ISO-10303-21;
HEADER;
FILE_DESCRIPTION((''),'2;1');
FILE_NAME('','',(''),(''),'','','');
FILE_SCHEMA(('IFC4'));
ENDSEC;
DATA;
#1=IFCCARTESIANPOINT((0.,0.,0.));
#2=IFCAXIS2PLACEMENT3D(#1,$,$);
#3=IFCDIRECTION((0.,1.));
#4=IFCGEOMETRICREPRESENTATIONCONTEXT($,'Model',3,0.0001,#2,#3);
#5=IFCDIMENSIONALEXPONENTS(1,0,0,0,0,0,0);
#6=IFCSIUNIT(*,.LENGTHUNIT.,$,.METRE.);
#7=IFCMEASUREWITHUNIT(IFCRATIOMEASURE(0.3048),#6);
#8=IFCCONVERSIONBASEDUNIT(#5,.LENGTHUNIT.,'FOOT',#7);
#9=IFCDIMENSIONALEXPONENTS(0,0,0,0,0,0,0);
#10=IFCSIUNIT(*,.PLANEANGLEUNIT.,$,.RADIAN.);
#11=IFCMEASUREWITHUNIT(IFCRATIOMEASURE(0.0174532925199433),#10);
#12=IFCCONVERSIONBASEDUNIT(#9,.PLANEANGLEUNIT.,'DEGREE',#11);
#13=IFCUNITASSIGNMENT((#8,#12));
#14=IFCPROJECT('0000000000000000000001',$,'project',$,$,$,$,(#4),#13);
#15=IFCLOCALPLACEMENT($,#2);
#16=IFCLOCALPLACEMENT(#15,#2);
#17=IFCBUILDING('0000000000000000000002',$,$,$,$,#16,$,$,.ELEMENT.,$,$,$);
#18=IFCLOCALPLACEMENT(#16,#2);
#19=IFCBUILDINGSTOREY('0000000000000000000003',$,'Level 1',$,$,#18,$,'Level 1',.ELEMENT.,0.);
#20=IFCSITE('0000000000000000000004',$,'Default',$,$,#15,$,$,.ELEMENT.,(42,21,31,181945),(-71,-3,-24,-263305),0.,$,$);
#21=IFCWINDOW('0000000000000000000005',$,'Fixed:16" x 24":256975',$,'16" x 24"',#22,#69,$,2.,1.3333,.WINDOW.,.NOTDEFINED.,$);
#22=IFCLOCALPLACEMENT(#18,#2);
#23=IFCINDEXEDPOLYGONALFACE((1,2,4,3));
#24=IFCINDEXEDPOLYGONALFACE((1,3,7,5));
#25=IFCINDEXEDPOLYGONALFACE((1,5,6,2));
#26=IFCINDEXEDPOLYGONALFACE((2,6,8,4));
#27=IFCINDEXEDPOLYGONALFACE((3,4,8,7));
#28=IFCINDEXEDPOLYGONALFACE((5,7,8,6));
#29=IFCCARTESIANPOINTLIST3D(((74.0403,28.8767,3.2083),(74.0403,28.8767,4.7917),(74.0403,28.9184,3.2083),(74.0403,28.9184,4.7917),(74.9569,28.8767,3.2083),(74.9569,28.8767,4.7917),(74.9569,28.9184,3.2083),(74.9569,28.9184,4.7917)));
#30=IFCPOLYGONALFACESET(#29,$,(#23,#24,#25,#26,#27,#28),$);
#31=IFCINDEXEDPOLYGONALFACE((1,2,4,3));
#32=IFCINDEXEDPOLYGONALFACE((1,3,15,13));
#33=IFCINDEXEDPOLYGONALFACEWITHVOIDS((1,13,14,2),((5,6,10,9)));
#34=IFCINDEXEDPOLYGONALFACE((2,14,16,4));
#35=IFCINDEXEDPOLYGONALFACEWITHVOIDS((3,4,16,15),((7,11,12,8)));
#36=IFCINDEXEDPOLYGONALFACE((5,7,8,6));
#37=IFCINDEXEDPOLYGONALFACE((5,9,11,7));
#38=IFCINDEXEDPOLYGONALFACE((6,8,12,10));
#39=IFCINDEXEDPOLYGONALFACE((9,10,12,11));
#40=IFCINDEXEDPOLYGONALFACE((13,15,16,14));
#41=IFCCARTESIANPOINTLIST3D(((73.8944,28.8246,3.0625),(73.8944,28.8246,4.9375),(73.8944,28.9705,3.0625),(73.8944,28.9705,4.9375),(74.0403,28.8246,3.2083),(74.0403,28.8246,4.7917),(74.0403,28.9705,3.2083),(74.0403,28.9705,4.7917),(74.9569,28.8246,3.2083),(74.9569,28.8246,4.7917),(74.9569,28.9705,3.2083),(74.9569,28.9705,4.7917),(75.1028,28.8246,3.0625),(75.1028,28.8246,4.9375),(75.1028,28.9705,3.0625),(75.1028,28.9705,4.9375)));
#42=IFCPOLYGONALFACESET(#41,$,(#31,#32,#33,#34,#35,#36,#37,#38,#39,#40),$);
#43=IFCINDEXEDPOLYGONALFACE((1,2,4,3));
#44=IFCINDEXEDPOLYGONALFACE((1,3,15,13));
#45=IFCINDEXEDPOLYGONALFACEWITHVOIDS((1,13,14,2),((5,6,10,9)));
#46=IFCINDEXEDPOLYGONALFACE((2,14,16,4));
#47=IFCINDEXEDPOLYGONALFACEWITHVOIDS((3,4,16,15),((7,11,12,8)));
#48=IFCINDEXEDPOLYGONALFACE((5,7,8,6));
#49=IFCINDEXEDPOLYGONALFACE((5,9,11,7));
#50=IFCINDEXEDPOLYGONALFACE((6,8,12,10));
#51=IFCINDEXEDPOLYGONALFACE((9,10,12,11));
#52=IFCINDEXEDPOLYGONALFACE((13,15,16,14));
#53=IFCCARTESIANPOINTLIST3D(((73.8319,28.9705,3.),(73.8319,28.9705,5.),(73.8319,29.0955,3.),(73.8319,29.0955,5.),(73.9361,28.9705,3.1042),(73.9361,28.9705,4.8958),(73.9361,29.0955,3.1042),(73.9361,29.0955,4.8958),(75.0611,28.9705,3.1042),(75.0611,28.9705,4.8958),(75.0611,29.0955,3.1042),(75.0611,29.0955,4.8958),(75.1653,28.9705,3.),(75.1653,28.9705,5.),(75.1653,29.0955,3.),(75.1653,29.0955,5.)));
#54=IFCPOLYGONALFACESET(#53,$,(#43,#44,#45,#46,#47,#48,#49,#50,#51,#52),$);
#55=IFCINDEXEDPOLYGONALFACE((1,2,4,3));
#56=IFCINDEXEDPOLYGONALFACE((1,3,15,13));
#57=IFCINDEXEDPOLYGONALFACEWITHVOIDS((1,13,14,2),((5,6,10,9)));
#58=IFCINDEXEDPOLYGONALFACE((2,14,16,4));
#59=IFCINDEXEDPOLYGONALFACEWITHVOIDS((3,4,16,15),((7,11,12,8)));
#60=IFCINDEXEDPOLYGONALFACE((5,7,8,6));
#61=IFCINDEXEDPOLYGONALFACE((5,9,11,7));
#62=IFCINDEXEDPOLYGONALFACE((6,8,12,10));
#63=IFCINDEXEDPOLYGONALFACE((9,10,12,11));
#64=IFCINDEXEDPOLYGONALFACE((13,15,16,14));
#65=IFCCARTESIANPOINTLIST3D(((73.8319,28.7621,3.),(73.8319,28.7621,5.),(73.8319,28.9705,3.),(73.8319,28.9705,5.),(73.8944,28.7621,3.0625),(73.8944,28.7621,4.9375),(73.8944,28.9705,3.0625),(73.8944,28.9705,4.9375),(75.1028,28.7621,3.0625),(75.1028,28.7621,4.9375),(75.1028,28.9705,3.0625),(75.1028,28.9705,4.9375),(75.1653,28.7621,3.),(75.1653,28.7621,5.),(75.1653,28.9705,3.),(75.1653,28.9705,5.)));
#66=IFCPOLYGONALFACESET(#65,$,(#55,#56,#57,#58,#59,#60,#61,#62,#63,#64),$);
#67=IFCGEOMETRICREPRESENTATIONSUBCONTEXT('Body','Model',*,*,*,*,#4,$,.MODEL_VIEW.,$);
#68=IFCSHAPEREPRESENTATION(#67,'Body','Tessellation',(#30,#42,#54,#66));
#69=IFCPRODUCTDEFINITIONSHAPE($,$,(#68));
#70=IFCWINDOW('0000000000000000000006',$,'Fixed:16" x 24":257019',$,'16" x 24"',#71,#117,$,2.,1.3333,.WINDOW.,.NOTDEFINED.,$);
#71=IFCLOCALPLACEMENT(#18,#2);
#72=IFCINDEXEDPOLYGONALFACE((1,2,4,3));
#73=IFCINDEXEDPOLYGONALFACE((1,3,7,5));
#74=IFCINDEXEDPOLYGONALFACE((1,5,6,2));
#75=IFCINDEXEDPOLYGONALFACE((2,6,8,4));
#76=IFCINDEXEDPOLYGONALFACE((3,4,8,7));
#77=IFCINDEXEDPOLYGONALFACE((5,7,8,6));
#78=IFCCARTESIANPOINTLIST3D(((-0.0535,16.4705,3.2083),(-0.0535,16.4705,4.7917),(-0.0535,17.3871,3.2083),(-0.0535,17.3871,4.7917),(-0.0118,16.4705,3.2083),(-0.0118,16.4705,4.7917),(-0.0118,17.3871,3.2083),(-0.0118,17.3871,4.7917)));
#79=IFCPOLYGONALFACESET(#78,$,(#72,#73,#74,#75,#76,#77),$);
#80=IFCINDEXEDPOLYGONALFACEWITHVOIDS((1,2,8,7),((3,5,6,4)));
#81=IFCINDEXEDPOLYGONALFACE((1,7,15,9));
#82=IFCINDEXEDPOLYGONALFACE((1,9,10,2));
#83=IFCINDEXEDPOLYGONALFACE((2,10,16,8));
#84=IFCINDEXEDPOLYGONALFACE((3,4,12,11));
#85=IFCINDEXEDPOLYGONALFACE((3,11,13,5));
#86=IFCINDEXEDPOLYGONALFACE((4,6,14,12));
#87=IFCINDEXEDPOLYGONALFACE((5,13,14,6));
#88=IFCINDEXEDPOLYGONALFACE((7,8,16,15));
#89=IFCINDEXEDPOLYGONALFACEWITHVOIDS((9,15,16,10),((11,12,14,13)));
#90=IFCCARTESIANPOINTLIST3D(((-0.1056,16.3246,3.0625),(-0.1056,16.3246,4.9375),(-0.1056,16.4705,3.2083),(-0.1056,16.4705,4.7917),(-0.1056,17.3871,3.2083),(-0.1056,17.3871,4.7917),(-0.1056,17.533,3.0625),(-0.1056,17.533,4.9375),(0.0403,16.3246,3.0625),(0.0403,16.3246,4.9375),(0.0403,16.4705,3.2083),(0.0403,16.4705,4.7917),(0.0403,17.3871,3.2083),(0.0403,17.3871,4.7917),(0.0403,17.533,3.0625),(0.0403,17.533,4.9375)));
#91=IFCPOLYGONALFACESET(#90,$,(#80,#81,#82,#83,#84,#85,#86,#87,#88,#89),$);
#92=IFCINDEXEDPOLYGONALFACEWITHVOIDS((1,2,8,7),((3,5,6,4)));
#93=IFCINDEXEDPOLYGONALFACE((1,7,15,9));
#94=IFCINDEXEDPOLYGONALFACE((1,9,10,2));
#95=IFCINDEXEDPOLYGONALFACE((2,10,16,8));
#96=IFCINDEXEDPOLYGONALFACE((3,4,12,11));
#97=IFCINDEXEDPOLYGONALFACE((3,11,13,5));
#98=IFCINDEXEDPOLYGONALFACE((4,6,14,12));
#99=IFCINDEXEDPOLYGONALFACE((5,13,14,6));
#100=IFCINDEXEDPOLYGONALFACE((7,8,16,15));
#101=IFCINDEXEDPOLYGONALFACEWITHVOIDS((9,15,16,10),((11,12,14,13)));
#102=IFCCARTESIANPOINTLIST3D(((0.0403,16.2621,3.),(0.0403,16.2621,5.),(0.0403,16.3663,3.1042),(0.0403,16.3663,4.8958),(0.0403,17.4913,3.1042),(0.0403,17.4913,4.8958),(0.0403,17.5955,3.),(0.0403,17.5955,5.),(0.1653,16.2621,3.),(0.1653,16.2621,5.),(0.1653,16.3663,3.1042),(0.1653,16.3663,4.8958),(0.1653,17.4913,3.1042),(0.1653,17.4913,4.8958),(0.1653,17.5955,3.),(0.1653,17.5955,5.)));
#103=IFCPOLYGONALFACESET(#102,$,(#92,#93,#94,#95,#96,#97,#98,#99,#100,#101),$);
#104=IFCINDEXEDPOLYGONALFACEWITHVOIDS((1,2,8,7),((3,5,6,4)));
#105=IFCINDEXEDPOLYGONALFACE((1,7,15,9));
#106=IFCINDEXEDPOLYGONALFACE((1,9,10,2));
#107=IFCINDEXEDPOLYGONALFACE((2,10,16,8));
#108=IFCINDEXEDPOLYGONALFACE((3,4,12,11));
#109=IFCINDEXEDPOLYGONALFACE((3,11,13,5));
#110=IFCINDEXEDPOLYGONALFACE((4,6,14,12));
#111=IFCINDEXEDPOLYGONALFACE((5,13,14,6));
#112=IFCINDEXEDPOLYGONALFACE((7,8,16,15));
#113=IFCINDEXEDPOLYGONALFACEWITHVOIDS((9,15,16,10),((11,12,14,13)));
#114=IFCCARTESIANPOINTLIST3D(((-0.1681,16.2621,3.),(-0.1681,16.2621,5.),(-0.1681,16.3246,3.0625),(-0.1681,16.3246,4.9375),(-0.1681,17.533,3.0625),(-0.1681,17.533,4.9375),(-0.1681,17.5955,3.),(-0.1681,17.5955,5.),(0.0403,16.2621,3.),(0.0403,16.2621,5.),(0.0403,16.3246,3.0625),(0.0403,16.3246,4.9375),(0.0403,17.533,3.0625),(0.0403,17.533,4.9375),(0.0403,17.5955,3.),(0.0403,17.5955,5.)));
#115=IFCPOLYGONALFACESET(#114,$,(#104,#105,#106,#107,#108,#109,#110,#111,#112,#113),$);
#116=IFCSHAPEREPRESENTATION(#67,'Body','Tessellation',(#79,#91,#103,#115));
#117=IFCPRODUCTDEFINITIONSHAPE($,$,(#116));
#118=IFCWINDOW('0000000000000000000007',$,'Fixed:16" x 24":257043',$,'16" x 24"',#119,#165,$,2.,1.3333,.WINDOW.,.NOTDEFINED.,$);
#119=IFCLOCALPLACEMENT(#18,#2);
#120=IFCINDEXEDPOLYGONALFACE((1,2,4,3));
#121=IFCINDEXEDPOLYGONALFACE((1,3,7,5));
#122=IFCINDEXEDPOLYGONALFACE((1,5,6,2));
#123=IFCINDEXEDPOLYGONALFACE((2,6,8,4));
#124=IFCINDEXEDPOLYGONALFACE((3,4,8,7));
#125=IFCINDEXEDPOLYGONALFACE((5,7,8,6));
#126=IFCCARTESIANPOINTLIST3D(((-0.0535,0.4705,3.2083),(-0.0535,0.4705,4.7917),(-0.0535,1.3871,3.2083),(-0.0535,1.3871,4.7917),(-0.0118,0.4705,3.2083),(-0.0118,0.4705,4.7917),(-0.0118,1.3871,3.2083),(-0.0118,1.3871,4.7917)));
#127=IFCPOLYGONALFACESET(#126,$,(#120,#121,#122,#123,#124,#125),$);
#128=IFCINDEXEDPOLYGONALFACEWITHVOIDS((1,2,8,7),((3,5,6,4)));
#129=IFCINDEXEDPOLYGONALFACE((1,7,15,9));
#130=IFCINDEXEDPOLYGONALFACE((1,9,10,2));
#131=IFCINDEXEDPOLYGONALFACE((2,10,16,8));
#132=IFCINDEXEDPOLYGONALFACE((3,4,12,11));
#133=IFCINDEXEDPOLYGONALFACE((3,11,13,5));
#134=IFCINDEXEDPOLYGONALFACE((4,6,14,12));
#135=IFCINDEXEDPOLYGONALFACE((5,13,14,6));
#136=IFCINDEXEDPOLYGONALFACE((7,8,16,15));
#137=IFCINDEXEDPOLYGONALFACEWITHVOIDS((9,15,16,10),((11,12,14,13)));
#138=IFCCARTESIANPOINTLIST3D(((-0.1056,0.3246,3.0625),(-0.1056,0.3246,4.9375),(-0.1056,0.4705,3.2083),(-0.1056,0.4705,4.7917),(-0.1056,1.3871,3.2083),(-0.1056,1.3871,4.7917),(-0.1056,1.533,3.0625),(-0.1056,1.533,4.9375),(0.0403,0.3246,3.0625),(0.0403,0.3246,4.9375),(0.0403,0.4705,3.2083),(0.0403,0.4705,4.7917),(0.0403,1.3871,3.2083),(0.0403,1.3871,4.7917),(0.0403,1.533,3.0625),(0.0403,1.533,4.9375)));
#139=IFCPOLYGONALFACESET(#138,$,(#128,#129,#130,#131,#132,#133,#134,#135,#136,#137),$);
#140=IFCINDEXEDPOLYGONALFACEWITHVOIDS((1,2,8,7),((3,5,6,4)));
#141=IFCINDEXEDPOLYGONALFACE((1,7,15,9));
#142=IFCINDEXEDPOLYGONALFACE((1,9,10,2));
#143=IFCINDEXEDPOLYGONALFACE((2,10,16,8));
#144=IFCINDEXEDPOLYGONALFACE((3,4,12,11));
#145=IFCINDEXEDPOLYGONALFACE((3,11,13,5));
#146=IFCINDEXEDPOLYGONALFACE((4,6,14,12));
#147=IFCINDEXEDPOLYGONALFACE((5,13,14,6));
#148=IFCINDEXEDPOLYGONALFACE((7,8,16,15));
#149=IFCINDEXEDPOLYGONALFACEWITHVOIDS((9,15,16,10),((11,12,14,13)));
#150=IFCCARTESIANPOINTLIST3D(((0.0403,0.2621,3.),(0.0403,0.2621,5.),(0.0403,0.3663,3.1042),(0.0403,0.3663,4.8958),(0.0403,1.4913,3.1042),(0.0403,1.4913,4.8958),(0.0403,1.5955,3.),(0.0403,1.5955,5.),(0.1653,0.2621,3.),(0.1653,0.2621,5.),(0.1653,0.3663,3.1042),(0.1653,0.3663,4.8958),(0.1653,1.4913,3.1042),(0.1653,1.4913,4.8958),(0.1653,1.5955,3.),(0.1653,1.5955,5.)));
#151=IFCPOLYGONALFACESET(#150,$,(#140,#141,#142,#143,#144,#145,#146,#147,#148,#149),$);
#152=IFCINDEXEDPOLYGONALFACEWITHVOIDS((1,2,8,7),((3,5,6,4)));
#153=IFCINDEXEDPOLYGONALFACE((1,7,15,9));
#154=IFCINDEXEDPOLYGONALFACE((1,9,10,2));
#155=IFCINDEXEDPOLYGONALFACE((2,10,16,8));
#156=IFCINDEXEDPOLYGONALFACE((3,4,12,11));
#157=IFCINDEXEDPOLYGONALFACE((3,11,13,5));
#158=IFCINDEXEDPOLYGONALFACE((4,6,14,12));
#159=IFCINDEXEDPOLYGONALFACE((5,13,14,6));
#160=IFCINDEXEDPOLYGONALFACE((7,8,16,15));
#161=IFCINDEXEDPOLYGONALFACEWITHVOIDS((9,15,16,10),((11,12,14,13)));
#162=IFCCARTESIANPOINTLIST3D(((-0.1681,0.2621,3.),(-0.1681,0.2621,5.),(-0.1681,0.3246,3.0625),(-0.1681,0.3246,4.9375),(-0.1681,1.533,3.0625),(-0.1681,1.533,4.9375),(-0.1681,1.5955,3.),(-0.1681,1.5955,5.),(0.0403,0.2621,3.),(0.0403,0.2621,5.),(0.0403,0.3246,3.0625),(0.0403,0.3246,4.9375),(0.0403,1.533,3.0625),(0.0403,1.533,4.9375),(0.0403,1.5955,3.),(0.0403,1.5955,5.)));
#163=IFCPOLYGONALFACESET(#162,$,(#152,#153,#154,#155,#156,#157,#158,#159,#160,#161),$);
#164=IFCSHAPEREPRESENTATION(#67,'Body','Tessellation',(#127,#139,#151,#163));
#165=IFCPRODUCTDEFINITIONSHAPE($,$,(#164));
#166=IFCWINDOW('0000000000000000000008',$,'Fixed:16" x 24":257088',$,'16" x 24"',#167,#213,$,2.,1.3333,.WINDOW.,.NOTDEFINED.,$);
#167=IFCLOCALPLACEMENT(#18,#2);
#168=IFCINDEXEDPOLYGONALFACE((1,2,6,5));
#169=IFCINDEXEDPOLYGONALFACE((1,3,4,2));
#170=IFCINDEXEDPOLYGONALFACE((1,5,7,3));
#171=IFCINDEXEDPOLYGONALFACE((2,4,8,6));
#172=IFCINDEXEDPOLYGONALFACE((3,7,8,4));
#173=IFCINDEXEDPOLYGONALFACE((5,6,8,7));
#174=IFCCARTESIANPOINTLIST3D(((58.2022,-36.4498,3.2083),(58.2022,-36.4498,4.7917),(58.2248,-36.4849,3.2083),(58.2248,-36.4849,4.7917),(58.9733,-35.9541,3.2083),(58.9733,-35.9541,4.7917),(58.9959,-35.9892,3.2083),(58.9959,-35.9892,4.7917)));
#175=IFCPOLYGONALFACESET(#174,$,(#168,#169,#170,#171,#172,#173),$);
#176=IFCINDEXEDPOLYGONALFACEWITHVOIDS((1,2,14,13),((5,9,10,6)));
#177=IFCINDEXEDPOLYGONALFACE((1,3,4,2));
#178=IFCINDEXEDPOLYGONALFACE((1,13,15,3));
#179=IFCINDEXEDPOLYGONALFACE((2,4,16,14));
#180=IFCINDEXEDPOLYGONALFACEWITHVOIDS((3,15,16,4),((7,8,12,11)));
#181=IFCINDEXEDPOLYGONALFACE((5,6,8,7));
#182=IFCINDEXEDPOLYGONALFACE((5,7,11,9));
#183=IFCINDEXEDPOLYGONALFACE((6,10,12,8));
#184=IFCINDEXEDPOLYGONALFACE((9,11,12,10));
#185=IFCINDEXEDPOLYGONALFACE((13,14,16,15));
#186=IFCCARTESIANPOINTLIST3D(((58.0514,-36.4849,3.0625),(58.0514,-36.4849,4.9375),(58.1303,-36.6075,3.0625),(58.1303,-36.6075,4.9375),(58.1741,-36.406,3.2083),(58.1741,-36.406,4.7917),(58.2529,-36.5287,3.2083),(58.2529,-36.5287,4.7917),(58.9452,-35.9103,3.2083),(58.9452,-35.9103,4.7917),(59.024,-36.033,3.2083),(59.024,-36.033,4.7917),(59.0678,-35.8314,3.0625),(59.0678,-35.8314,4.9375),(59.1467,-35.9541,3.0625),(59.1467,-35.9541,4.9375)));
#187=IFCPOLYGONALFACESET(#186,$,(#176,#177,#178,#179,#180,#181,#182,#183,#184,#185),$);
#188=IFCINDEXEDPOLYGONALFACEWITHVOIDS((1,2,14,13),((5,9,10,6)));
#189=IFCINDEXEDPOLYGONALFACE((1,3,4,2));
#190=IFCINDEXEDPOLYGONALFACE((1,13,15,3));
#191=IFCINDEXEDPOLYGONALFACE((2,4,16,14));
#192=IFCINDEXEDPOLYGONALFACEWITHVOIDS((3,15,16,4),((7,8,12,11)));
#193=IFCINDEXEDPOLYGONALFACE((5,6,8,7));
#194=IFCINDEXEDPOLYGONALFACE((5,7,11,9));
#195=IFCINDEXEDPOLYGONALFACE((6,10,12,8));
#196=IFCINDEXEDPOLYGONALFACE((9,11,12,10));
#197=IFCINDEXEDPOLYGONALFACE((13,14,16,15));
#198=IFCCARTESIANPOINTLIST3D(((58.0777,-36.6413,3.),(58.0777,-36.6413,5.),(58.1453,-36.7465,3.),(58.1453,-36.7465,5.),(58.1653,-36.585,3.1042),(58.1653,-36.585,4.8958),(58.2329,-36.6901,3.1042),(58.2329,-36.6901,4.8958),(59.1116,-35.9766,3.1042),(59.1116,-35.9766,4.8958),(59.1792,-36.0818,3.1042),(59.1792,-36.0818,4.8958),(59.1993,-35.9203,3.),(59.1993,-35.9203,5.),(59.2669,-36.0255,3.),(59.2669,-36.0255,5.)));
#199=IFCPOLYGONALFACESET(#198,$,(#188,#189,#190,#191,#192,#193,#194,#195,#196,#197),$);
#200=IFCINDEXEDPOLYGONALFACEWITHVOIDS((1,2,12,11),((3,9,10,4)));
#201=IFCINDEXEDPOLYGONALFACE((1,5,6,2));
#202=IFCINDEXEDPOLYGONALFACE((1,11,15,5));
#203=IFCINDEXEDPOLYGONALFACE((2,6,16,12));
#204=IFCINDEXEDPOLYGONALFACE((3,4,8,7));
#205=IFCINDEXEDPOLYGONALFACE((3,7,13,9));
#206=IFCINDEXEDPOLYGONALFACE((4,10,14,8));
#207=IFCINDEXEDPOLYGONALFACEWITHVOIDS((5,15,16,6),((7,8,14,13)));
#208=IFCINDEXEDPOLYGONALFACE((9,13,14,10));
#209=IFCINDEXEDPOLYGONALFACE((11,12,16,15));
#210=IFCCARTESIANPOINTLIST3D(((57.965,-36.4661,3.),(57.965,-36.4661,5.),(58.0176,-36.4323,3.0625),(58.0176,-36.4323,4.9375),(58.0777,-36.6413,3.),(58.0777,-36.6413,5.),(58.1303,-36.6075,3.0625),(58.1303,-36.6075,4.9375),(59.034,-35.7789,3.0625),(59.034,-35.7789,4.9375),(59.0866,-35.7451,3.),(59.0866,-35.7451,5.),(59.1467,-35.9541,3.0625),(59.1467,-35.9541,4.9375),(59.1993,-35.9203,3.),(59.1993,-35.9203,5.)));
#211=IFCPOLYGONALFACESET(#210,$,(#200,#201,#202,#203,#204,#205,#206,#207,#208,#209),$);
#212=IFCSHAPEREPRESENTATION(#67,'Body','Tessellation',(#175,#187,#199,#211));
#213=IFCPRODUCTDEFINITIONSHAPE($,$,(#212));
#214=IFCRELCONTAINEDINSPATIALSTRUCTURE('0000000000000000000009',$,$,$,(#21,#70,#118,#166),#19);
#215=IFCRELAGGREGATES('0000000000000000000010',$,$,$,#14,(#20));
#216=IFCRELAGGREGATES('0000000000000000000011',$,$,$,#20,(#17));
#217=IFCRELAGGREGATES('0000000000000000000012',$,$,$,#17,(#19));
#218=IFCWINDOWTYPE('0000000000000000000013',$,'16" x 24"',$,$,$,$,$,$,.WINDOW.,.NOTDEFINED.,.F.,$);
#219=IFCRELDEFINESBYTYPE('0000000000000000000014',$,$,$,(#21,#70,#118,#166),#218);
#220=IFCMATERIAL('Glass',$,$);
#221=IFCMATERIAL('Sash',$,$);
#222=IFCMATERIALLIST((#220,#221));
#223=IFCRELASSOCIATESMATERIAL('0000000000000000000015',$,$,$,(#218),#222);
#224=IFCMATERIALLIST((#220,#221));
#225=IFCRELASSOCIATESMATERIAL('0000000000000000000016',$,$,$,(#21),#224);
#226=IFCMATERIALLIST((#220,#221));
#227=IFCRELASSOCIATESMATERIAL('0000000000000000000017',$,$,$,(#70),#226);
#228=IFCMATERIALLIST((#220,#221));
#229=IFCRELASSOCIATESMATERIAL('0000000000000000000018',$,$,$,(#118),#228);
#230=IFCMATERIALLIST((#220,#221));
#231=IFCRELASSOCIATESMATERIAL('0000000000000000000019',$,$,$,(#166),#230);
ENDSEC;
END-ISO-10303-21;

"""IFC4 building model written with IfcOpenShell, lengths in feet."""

from ifc_helpers import new_model, entity, si_unit, converted_unit, direction, frame, origin, origin_2d_with_axis, place, context, subcontext, project, spatial, polyline, rectangle, outline, extrude, source, transform, mapped, material, material_list, type_object, type_shapes, element, save


model = new_model("IFC4")

# Units and contexts
model_context = context("Model", 3, precision=0.0001, world=origin(), true_north=direction((0.0, 1.0)))
body_context = subcontext(model_context, "Body", "Model", "MODEL_VIEW")
ifc_project = project(units=[converted_unit("LENGTHUNIT", "FOOT", entity("IfcRatioMeasure", 0.3048), si_unit("LENGTHUNIT", "METRE"), dimensions=[1, 0, 0, 0, 0, 0, 0]), converted_unit("PLANEANGLEUNIT", "DEGREE", entity("IfcRatioMeasure", 0.0174532925199433), si_unit("PLANEANGLEUNIT", "RADIAN"), dimensions=[0, 0, 0, 0, 0, 0, 0])], contexts=[model_context])

# Site, building, storey
site_placement = place(None, origin())
site = spatial("IfcSite", under=ifc_project, at=site_placement, Name="Default", CompositionType="ELEMENT", RefLatitude=(42, 21, 31, 181945), RefLongitude=(-71, -3, -24, -263305), RefElevation=0.0)
building_placement = place(site_placement, origin())
building = spatial("IfcBuilding", under=site, at=building_placement, CompositionType="ELEMENT")
storey_placement = place(building_placement, origin())
storey = spatial("IfcBuildingStorey", under=building, at=storey_placement, Name="Level 1", LongName="Level 1", CompositionType="ELEMENT", Elevation=0.0)

# Windows
ifc_material_1 = material(Name="Glass")
ifc_material_2 = material(Name="Sash")
ifc_material_list_1 = material_list([ifc_material_1, ifc_material_2])
window_type = type_object("IfcWindowType", Name="16\" x 24\"", ParameterTakesPrecedence=False, PartitioningType="NOTDEFINED", PredefinedType="WINDOW", material=ifc_material_list_1)
shared_shape_1 = source(origin(), body_context, "Body", "SweptSolid", [
    extrude(rectangle(XDim=0.0417, YDim=0.9167, at=origin_2d_with_axis()), frame((0.6667, 0.1979, 0.2083), z_axis=(0.0, 0.0, 1.0), x_axis=(0.0, 1.0, 0.0)), (0.0, 0.0, 1.0), 1.5833),
    extrude(outline(polyline([(-0.6042, -0.9375), (0.6042, -0.9375), (0.6042, 0.9375), (-0.6042, 0.9375), (-0.6042, -0.9375)]), holes=[polyline([(-0.4583, -0.7917), (-0.4583, 0.7917), (0.4583, 0.7917), (0.4583, -0.7917), (-0.4583, -0.7917)])]), frame((0.6667, 0.125, 1.0), z_axis=(0.0, 1.0, 0.0), x_axis=(1.0, 0.0, 0.0)), (0.0, 0.0, 1.0), 0.1458),
    extrude(outline(polyline([(-0.6667, -1.0), (0.6667, -1.0), (0.6667, 1.0), (-0.6667, 1.0), (-0.6667, -1.0)]), holes=[polyline([(-0.5625, -0.8958), (-0.5625, 0.8958), (0.5625, 0.8958), (0.5625, -0.8958), (-0.5625, -0.8958)])]), frame((0.6667, 0.0, 1.0), z_axis=(0.0, 1.0, 0.0), x_axis=(1.0, 0.0, 0.0)), (0.0, 0.0, 1.0), 0.125),
    extrude(outline(polyline([(-1.0, -0.6667), (1.0, -0.6667), (1.0, 0.6667), (-1.0, 0.6667), (-1.0, -0.6667)]), holes=[polyline([(-0.9375, -0.6042), (-0.9375, 0.6042), (0.9375, 0.6042), (0.9375, -0.6042), (-0.9375, -0.6042)])]), frame((0.6667, 0.125, 1.0), z_axis=(0.0, 1.0, 0.0), x_axis=(0.0, 0.0, -1.0)), (0.0, 0.0, 1.0), 0.2083),
])
type_shapes(window_type, [shared_shape_1])
placement_1 = place(storey_placement, frame((-0.1681, 28.9288, 0.0)))
ifc_material_list_2 = material_list([ifc_material_1, ifc_material_2])
placement_2 = place(placement_1, frame((75.3333, 0.1667, 3.0)))
window_1_placement = place(placement_2, frame((0.0, 0.0, 0.0), z_axis=(0.0, 0.0, 1.0), x_axis=(-1.0, 0.0, 0.0)))
element("IfcWindow", 1, at=window_1_placement, inside=storey, type_object=window_type, material=ifc_material_list_2, Name="Fixed:16\" x 24\":256975", ObjectType="16\" x 24\"", OverallHeight=2.0, OverallWidth=1.3333, PartitioningType="NOTDEFINED", PredefinedType="WINDOW", context=body_context, shape_type="MappedRepresentation", body=[
    mapped(shared_shape_1, transform((0.0, 0.0, 0.0), scale=1.0)),
])
ifc_material_list_3 = material_list([ifc_material_1, ifc_material_2])
placement_3 = place(storey_placement, frame((-0.0014, -6.9045, 0.0), z_axis=(0.0, 0.0, 1.0), x_axis=(0.0, 1.0, 0.0)))
placement_4 = place(placement_3, frame((23.1667, -0.1667, 3.0)))
window_2_placement = place(placement_4, origin())
element("IfcWindow", 2, at=window_2_placement, inside=storey, type_object=window_type, material=ifc_material_list_3, Name="Fixed:16\" x 24\":257019", ObjectType="16\" x 24\"", OverallHeight=2.0, OverallWidth=1.3333, PartitioningType="NOTDEFINED", PredefinedType="WINDOW", context=body_context, shape_type="MappedRepresentation", body=[
    mapped(shared_shape_1, transform((0.0, 0.0, 0.0), scale=1.0)),
])
ifc_material_list_4 = material_list([ifc_material_1, ifc_material_2])
placement_5 = place(placement_3, frame((7.1667, -0.1667, 3.0)))
window_3_placement = place(placement_5, origin())
element("IfcWindow", 3, at=window_3_placement, inside=storey, type_object=window_type, material=ifc_material_list_4, Name="Fixed:16\" x 24\":257043", ObjectType="16\" x 24\"", OverallHeight=2.0, OverallWidth=1.3333, PartitioningType="NOTDEFINED", PredefinedType="WINDOW", context=body_context, shape_type="MappedRepresentation", body=[
    mapped(shared_shape_1, transform((0.0, 0.0, 0.0), scale=1.0)),
])
ifc_material_list_5 = material_list([ifc_material_1, ifc_material_2])
placement_6 = place(storey_placement, frame((103.9574, -7.0977, 0.0), z_axis=(0.0, 0.0, 1.0), x_axis=(-0.841178, -0.540758, 0.0)))
placement_7 = place(placement_6, frame((54.569, 0.1667, 3.0)))
window_4_placement = place(placement_7, frame((0.0, 0.0, 0.0), z_axis=(0.0, 0.0, 1.0), x_axis=(-1.0, 0.0, 0.0)))
element("IfcWindow", 4, at=window_4_placement, inside=storey, type_object=window_type, material=ifc_material_list_5, Name="Fixed:16\" x 24\":257088", ObjectType="16\" x 24\"", OverallHeight=2.0, OverallWidth=1.3333, PartitioningType="NOTDEFINED", PredefinedType="WINDOW", context=body_context, shape_type="MappedRepresentation", body=[
    mapped(shared_shape_1, transform((0.0, 0.0, 0.0), scale=1.0)),
])

save(model, "model.ifc")
